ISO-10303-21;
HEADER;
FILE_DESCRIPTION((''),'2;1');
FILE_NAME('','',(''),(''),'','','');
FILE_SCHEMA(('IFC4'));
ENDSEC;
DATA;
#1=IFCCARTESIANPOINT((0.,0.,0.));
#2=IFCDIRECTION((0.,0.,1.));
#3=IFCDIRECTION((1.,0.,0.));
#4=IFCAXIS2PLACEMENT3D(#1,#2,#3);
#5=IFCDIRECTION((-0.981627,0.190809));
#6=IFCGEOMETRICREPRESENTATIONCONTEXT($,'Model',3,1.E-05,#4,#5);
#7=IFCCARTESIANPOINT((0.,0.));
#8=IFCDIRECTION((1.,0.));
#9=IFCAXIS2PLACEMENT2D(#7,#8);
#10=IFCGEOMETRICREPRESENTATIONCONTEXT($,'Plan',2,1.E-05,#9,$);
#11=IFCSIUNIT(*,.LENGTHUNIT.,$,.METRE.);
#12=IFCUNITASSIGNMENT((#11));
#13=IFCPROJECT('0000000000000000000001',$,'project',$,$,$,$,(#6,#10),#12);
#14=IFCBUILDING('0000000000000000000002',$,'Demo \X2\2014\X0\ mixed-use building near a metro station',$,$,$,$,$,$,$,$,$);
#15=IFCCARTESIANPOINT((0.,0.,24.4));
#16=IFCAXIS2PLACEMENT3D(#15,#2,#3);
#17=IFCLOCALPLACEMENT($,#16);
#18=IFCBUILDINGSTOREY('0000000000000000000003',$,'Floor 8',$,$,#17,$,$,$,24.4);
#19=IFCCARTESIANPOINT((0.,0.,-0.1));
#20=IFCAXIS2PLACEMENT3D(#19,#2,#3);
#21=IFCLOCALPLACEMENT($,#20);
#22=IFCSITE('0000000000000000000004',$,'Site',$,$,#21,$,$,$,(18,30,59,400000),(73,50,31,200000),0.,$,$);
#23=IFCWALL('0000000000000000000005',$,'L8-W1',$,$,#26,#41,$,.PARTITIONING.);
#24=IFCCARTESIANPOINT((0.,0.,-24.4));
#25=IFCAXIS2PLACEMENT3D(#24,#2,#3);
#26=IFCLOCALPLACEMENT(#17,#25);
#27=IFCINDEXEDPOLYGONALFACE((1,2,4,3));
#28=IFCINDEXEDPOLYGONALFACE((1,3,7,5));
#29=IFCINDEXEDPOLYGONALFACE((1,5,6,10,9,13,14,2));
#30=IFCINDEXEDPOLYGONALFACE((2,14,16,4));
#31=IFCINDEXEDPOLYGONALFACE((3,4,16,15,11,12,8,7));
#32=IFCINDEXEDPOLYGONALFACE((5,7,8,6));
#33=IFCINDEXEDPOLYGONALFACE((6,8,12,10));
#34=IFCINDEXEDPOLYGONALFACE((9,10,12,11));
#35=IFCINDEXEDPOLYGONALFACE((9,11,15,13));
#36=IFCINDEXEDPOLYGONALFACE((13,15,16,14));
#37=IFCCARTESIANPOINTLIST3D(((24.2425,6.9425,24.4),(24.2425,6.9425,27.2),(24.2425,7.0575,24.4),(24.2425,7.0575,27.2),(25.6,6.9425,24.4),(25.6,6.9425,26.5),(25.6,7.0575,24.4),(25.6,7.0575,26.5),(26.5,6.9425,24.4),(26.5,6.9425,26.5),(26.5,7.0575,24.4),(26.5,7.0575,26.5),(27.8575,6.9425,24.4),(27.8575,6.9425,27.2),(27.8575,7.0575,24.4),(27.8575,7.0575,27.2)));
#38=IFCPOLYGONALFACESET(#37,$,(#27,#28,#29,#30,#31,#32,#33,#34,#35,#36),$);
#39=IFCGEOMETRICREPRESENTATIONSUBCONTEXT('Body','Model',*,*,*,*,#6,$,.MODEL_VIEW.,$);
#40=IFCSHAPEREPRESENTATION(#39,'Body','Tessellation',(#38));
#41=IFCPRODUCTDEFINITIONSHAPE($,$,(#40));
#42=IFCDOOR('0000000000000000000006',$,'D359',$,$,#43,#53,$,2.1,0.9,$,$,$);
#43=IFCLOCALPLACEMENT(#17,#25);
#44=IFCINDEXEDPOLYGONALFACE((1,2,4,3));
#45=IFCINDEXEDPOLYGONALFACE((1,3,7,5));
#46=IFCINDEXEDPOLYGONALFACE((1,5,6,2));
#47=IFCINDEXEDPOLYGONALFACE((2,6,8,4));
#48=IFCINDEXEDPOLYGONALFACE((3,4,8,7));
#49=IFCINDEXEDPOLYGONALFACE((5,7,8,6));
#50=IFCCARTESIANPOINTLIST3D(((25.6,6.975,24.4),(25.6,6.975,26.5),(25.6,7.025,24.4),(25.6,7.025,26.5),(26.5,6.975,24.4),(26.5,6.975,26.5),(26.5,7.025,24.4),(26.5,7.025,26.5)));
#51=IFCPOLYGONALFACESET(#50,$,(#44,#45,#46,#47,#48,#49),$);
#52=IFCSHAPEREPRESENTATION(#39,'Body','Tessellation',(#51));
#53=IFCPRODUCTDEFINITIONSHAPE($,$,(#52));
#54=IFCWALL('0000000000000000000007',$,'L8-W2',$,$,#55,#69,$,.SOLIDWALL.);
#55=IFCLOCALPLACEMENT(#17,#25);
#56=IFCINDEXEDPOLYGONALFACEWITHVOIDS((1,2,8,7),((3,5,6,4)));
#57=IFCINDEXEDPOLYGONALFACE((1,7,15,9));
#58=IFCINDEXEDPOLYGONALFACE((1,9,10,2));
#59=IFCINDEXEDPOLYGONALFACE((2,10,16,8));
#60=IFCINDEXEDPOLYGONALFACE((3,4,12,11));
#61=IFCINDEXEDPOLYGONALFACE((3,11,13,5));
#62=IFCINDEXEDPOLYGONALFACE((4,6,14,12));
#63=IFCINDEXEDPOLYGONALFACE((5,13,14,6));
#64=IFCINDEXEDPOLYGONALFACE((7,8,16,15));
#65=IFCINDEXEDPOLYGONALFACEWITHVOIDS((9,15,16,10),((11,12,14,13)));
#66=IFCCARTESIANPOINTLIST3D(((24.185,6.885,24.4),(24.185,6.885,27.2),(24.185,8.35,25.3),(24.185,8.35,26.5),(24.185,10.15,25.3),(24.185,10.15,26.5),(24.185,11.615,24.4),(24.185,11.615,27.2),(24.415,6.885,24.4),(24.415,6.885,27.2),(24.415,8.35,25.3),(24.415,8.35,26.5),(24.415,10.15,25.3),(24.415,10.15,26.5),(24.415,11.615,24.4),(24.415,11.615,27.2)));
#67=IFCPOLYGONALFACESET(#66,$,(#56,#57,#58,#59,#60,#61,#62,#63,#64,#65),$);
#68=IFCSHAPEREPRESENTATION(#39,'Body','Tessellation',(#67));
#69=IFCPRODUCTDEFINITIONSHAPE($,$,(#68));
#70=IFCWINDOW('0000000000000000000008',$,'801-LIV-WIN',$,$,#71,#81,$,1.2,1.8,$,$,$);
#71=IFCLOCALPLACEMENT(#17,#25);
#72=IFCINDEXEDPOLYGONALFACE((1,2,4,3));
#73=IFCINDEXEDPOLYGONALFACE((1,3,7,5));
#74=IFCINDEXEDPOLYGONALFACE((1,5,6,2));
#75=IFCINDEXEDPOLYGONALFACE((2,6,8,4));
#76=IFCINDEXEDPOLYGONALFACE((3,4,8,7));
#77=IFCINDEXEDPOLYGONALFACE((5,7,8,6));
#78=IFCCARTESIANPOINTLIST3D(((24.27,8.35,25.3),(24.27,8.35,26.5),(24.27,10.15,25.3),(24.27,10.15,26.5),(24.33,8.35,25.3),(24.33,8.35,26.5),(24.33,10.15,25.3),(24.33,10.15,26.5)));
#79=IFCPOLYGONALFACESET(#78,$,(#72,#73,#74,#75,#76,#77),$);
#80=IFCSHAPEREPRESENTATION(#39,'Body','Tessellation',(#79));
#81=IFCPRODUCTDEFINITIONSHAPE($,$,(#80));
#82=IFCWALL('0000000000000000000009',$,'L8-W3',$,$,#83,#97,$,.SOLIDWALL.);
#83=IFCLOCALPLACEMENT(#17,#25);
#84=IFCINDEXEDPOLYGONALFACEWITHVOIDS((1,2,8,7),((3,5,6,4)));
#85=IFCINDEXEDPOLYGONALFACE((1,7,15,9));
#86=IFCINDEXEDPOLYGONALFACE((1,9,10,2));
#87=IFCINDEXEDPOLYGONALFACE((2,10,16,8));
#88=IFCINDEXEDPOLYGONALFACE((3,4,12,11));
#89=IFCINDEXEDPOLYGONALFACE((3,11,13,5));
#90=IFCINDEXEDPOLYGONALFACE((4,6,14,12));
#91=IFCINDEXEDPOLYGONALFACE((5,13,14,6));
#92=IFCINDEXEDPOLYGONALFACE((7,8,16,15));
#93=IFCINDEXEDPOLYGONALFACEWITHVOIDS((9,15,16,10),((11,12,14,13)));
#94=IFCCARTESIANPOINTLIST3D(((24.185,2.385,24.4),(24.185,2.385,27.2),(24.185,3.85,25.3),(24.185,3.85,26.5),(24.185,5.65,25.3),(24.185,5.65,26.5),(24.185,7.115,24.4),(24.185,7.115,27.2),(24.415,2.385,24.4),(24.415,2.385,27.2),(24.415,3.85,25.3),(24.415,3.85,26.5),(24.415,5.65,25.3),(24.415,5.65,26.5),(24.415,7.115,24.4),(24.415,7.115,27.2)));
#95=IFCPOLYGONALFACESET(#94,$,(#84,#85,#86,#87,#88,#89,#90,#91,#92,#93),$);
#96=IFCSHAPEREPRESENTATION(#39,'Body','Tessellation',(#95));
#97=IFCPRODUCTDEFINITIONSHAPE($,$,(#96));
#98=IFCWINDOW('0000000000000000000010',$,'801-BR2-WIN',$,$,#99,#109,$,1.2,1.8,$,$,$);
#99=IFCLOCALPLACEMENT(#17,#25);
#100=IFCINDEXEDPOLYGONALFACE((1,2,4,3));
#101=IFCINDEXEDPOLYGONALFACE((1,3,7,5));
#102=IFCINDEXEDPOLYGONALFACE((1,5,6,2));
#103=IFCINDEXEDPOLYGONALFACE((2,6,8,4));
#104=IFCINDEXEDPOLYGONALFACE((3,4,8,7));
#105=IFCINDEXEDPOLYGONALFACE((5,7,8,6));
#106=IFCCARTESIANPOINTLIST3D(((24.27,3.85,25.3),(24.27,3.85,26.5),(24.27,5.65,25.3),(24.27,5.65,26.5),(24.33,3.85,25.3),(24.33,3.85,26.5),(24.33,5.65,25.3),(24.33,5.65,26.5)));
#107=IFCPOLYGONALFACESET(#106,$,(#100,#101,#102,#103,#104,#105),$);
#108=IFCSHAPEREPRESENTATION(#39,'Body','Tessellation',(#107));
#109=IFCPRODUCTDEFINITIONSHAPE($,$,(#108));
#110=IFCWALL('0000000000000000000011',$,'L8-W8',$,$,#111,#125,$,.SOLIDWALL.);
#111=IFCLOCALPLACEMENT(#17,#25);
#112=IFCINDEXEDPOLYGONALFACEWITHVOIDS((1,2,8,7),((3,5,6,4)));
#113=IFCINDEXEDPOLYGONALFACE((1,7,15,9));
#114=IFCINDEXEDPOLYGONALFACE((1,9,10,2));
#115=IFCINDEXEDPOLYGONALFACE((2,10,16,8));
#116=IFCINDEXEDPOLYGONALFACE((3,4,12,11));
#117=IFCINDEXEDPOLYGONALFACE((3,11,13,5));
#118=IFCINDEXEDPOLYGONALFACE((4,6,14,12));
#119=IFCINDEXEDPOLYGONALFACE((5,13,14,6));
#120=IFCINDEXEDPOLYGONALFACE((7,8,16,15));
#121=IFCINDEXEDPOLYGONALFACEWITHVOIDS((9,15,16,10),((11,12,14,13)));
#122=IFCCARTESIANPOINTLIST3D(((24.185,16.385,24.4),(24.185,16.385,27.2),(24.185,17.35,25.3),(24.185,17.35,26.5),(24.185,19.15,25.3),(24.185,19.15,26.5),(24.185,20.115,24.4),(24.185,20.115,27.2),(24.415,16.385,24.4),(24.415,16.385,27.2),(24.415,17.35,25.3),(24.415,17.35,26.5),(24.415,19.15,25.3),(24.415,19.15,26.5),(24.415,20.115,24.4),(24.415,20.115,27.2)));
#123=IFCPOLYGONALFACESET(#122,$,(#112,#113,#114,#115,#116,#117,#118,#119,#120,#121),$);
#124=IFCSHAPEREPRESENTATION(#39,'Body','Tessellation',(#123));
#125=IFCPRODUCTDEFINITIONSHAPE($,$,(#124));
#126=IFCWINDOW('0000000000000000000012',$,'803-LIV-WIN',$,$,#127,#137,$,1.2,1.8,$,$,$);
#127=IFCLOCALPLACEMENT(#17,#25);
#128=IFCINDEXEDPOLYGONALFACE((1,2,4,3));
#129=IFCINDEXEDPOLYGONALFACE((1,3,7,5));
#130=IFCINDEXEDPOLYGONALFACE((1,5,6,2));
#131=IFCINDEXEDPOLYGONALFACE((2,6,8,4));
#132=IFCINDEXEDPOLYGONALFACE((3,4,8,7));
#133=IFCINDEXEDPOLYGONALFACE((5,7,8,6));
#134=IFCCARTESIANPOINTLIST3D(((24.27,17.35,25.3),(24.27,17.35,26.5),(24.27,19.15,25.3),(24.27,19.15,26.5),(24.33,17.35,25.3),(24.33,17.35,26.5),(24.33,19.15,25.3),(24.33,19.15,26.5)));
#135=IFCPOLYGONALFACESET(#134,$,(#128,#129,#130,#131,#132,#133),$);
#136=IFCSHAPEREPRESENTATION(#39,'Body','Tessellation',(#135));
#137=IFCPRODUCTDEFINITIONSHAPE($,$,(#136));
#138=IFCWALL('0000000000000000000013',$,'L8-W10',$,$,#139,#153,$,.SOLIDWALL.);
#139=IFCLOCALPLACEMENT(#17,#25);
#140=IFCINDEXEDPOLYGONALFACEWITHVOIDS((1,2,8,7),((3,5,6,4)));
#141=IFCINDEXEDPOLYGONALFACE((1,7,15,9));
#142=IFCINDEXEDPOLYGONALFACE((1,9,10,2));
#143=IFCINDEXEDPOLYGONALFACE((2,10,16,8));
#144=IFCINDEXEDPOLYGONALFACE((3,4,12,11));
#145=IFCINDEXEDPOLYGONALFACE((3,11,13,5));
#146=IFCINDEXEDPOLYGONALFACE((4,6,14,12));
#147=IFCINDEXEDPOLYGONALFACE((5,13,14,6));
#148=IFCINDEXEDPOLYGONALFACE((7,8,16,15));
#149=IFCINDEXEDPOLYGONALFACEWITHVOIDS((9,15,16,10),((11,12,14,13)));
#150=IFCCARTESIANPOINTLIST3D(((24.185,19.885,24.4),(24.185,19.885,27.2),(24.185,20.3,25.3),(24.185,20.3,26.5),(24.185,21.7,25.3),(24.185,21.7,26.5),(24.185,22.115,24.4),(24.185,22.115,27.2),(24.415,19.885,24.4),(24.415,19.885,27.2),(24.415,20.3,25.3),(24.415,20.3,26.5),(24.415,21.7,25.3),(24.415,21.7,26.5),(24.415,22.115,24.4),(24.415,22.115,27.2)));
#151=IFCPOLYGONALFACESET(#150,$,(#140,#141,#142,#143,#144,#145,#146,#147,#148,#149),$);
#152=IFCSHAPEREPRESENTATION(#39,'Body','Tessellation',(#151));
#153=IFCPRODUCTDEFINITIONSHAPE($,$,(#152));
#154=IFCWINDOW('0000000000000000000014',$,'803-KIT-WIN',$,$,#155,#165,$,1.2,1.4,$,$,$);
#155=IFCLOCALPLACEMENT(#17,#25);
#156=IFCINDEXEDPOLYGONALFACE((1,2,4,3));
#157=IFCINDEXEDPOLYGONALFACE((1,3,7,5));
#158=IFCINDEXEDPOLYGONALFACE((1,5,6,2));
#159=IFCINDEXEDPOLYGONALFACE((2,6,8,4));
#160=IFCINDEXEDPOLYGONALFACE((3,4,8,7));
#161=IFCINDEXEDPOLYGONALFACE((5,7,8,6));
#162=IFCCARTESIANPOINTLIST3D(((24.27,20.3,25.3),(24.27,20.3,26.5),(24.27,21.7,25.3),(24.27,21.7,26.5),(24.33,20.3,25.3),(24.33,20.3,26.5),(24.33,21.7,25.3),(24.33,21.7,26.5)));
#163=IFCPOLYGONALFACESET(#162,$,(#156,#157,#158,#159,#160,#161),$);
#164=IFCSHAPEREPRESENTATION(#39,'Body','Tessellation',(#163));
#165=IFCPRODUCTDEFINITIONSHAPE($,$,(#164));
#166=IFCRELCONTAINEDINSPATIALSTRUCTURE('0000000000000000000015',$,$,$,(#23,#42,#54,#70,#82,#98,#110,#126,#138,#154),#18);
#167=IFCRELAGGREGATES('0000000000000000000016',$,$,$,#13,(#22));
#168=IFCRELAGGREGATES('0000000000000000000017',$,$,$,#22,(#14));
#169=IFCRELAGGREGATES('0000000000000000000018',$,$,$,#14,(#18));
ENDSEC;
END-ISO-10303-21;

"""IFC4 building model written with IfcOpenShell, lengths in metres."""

from ifc_helpers import new_model, si_unit, direction, frame, origin_with_axes, origin_2d_with_axis, place, context, subcontext, project, spatial, line, indexed_curve, outline, extrude, element, fill, save


model = new_model("IFC4")

# Units and contexts
model_context = context("Model", 3, precision=1e-05, world=origin_with_axes(), true_north=direction((-0.981627, 0.190809)))
plan_context = context("Plan", 2, precision=1e-05, world=origin_2d_with_axis())
body_context = subcontext(model_context, "Body", "Model", "MODEL_VIEW")
ifc_project = project(units=[si_unit("LENGTHUNIT", "METRE")], contexts=[model_context, plan_context])

# Site, building, storey
site_placement = place(None, frame((0.0, 0.0, -0.1), z_axis=(0.0, 0.0, 1.0), x_axis=(1.0, 0.0, 0.0)))
site = spatial("IfcSite", under=ifc_project, at=site_placement, Name="Site", RefLatitude=(18, 30, 59, 400000), RefLongitude=(73, 50, 31, 200000), RefElevation=0.0)
building = spatial("IfcBuilding", under=site, Name="Demo — mixed-use building near a metro station")
storey_placement = place(None, frame((0.0, 0.0, 24.4), z_axis=(0.0, 0.0, 1.0), x_axis=(1.0, 0.0, 0.0)))
storey = spatial("IfcBuildingStorey", under=building, at=storey_placement, Name="Floor 8", Elevation=24.4)

# Wall, opening, door
wall_1_placement = place(storey_placement, frame((0.0, 0.0, -24.4), z_axis=(0.0, 0.0, 1.0), x_axis=(1.0, 0.0, 0.0)))
wall_1 = element("IfcWall", 1, at=wall_1_placement, inside=storey, Name="L8-W1", PredefinedType="PARTITIONING", context=body_context, shape_type="SweptSolid", body=[
    extrude(outline(indexed_curve([(27.8575, 6.9425), (24.2425, 6.9425), (24.2425, 7.0575), (27.8575, 7.0575)], segments=[line(1, 2, 3, 4, 1)])), frame((0.0, 0.0, 24.4), z_axis=(0.0, 0.0, 1.0), x_axis=(1.0, 0.0, 0.0)), (0.0, 0.0, 1.0), 2.8),
])
opening_1_placement = place(wall_1_placement, origin_with_axes())
opening_1 = element("IfcOpeningElement", 2, at=opening_1_placement, cuts=wall_1, context=body_context, shape_type="SweptSolid", body=[
    extrude(outline(indexed_curve([(26.5, 6.8925), (25.6, 6.8925), (25.6, 7.1075), (26.5, 7.1075)], segments=[line(1, 2, 3, 4, 1)])), frame((0.0, 0.0, 24.4), z_axis=(0.0, 0.0, 1.0), x_axis=(1.0, 0.0, 0.0)), (0.0, 0.0, 1.0), 2.1),
])
door_placement = place(storey_placement, frame((0.0, 0.0, -24.4), z_axis=(0.0, 0.0, 1.0), x_axis=(1.0, 0.0, 0.0)))
door = element("IfcDoor", 3, at=door_placement, inside=storey, Name="D359", OverallHeight=2.1, OverallWidth=0.9, context=body_context, shape_type="SweptSolid", body=[
    extrude(outline(indexed_curve([(26.5, 6.975), (25.6, 6.975), (25.6, 7.025), (26.5, 7.025)], segments=[line(1, 2, 3, 4, 1)])), frame((0.0, 0.0, 24.4), z_axis=(0.0, 0.0, 1.0), x_axis=(1.0, 0.0, 0.0)), (0.0, 0.0, 1.0), 2.1),
])
fill(opening_1, door)

# Walls, openings, windows
wall_2_placement = place(storey_placement, frame((0.0, 0.0, -24.4), z_axis=(0.0, 0.0, 1.0), x_axis=(1.0, 0.0, 0.0)))
wall_2 = element("IfcWall", 4, at=wall_2_placement, inside=storey, Name="L8-W2", PredefinedType="SOLIDWALL", context=body_context, shape_type="SweptSolid", body=[
    extrude(outline(indexed_curve([(24.415, 11.615), (24.415, 6.885), (24.185, 6.885), (24.185, 11.615)], segments=[line(1, 2, 3, 4, 1)])), frame((0.0, 0.0, 24.4), z_axis=(0.0, 0.0, 1.0), x_axis=(1.0, 0.0, 0.0)), (0.0, 0.0, 1.0), 2.8),
])
opening_2_placement = place(wall_2_placement, origin_with_axes())
opening_2 = element("IfcOpeningElement", 5, at=opening_2_placement, cuts=wall_2, context=body_context, shape_type="SweptSolid", body=[
    extrude(outline(indexed_curve([(24.465, 10.15), (24.465, 8.35), (24.135, 8.35), (24.135, 10.15)], segments=[line(1, 2, 3, 4, 1)])), frame((0.0, 0.0, 25.3), z_axis=(0.0, 0.0, 1.0), x_axis=(1.0, 0.0, 0.0)), (0.0, 0.0, 1.0), 1.2),
])
window_1_placement = place(storey_placement, frame((0.0, 0.0, -24.4), z_axis=(0.0, 0.0, 1.0), x_axis=(1.0, 0.0, 0.0)))
window_1 = element("IfcWindow", 6, at=window_1_placement, inside=storey, Name="801-LIV-WIN", OverallHeight=1.2, OverallWidth=1.8, context=body_context, shape_type="SweptSolid", body=[
    extrude(outline(indexed_curve([(24.33, 10.15), (24.33, 8.35), (24.27, 8.35), (24.27, 10.15)], segments=[line(1, 2, 3, 4, 1)])), frame((0.0, 0.0, 25.3), z_axis=(0.0, 0.0, 1.0), x_axis=(1.0, 0.0, 0.0)), (0.0, 0.0, 1.0), 1.2),
])
fill(opening_2, window_1)
wall_3_placement = place(storey_placement, frame((0.0, 0.0, -24.4), z_axis=(0.0, 0.0, 1.0), x_axis=(1.0, 0.0, 0.0)))
wall_3 = element("IfcWall", 7, at=wall_3_placement, inside=storey, Name="L8-W3", PredefinedType="SOLIDWALL", context=body_context, shape_type="SweptSolid", body=[
    extrude(outline(indexed_curve([(24.415, 7.115), (24.415, 2.385), (24.185, 2.385), (24.185, 7.115)], segments=[line(1, 2, 3, 4, 1)])), frame((0.0, 0.0, 24.4), z_axis=(0.0, 0.0, 1.0), x_axis=(1.0, 0.0, 0.0)), (0.0, 0.0, 1.0), 2.8),
])
opening_3_placement = place(wall_3_placement, origin_with_axes())
opening_3 = element("IfcOpeningElement", 8, at=opening_3_placement, cuts=wall_3, context=body_context, shape_type="SweptSolid", body=[
    extrude(outline(indexed_curve([(24.465, 5.65), (24.465, 3.85), (24.135, 3.85), (24.135, 5.65)], segments=[line(1, 2, 3, 4, 1)])), frame((0.0, 0.0, 25.3), z_axis=(0.0, 0.0, 1.0), x_axis=(1.0, 0.0, 0.0)), (0.0, 0.0, 1.0), 1.2),
])
window_2_placement = place(storey_placement, frame((0.0, 0.0, -24.4), z_axis=(0.0, 0.0, 1.0), x_axis=(1.0, 0.0, 0.0)))
window_2 = element("IfcWindow", 9, at=window_2_placement, inside=storey, Name="801-BR2-WIN", OverallHeight=1.2, OverallWidth=1.8, context=body_context, shape_type="SweptSolid", body=[
    extrude(outline(indexed_curve([(24.33, 5.65), (24.33, 3.85), (24.27, 3.85), (24.27, 5.65)], segments=[line(1, 2, 3, 4, 1)])), frame((0.0, 0.0, 25.3), z_axis=(0.0, 0.0, 1.0), x_axis=(1.0, 0.0, 0.0)), (0.0, 0.0, 1.0), 1.2),
])
fill(opening_3, window_2)

# Wall, opening, window
wall_4_placement = place(storey_placement, frame((0.0, 0.0, -24.4), z_axis=(0.0, 0.0, 1.0), x_axis=(1.0, 0.0, 0.0)))
wall_4 = element("IfcWall", 10, at=wall_4_placement, inside=storey, Name="L8-W8", PredefinedType="SOLIDWALL", context=body_context, shape_type="SweptSolid", body=[
    extrude(outline(indexed_curve([(24.415, 20.115), (24.415, 16.385), (24.185, 16.385), (24.185, 20.115)], segments=[line(1, 2, 3, 4, 1)])), frame((0.0, 0.0, 24.4), z_axis=(0.0, 0.0, 1.0), x_axis=(1.0, 0.0, 0.0)), (0.0, 0.0, 1.0), 2.8),
])
opening_4_placement = place(wall_4_placement, origin_with_axes())
opening_4 = element("IfcOpeningElement", 11, at=opening_4_placement, cuts=wall_4, context=body_context, shape_type="SweptSolid", body=[
    extrude(outline(indexed_curve([(24.465, 19.15), (24.465, 17.35), (24.135, 17.35), (24.135, 19.15)], segments=[line(1, 2, 3, 4, 1)])), frame((0.0, 0.0, 25.3), z_axis=(0.0, 0.0, 1.0), x_axis=(1.0, 0.0, 0.0)), (0.0, 0.0, 1.0), 1.2),
])
window_3_placement = place(storey_placement, frame((0.0, 0.0, -24.4), z_axis=(0.0, 0.0, 1.0), x_axis=(1.0, 0.0, 0.0)))
window_3 = element("IfcWindow", 12, at=window_3_placement, inside=storey, Name="803-LIV-WIN", OverallHeight=1.2, OverallWidth=1.8, context=body_context, shape_type="SweptSolid", body=[
    extrude(outline(indexed_curve([(24.33, 19.15), (24.33, 17.35), (24.27, 17.35), (24.27, 19.15)], segments=[line(1, 2, 3, 4, 1)])), frame((0.0, 0.0, 25.3), z_axis=(0.0, 0.0, 1.0), x_axis=(1.0, 0.0, 0.0)), (0.0, 0.0, 1.0), 1.2),
])
fill(opening_4, window_3)

# Wall, opening, window
wall_5_placement = place(storey_placement, frame((0.0, 0.0, -24.4), z_axis=(0.0, 0.0, 1.0), x_axis=(1.0, 0.0, 0.0)))
wall_5 = element("IfcWall", 13, at=wall_5_placement, inside=storey, Name="L8-W10", PredefinedType="SOLIDWALL", context=body_context, shape_type="SweptSolid", body=[
    extrude(outline(indexed_curve([(24.415, 22.115), (24.415, 19.885), (24.185, 19.885), (24.185, 22.115)], segments=[line(1, 2, 3, 4, 1)])), frame((0.0, 0.0, 24.4), z_axis=(0.0, 0.0, 1.0), x_axis=(1.0, 0.0, 0.0)), (0.0, 0.0, 1.0), 2.8),
])
opening_5_placement = place(wall_5_placement, origin_with_axes())
opening_5 = element("IfcOpeningElement", 14, at=opening_5_placement, cuts=wall_5, context=body_context, shape_type="SweptSolid", body=[
    extrude(outline(indexed_curve([(24.465, 21.7), (24.465, 20.3), (24.135, 20.3), (24.135, 21.7)], segments=[line(1, 2, 3, 4, 1)])), frame((0.0, 0.0, 25.3), z_axis=(0.0, 0.0, 1.0), x_axis=(1.0, 0.0, 0.0)), (0.0, 0.0, 1.0), 1.2),
])
window_4_placement = place(storey_placement, frame((0.0, 0.0, -24.4), z_axis=(0.0, 0.0, 1.0), x_axis=(1.0, 0.0, 0.0)))
window_4 = element("IfcWindow", 15, at=window_4_placement, inside=storey, Name="803-KIT-WIN", OverallHeight=1.2, OverallWidth=1.4, context=body_context, shape_type="SweptSolid", body=[
    extrude(outline(indexed_curve([(24.33, 21.7), (24.33, 20.3), (24.27, 20.3), (24.27, 21.7)], segments=[line(1, 2, 3, 4, 1)])), frame((0.0, 0.0, 25.3), z_axis=(0.0, 0.0, 1.0), x_axis=(1.0, 0.0, 0.0)), (0.0, 0.0, 1.0), 1.2),
])
fill(opening_5, window_4)

save(model, "model.ifc")
